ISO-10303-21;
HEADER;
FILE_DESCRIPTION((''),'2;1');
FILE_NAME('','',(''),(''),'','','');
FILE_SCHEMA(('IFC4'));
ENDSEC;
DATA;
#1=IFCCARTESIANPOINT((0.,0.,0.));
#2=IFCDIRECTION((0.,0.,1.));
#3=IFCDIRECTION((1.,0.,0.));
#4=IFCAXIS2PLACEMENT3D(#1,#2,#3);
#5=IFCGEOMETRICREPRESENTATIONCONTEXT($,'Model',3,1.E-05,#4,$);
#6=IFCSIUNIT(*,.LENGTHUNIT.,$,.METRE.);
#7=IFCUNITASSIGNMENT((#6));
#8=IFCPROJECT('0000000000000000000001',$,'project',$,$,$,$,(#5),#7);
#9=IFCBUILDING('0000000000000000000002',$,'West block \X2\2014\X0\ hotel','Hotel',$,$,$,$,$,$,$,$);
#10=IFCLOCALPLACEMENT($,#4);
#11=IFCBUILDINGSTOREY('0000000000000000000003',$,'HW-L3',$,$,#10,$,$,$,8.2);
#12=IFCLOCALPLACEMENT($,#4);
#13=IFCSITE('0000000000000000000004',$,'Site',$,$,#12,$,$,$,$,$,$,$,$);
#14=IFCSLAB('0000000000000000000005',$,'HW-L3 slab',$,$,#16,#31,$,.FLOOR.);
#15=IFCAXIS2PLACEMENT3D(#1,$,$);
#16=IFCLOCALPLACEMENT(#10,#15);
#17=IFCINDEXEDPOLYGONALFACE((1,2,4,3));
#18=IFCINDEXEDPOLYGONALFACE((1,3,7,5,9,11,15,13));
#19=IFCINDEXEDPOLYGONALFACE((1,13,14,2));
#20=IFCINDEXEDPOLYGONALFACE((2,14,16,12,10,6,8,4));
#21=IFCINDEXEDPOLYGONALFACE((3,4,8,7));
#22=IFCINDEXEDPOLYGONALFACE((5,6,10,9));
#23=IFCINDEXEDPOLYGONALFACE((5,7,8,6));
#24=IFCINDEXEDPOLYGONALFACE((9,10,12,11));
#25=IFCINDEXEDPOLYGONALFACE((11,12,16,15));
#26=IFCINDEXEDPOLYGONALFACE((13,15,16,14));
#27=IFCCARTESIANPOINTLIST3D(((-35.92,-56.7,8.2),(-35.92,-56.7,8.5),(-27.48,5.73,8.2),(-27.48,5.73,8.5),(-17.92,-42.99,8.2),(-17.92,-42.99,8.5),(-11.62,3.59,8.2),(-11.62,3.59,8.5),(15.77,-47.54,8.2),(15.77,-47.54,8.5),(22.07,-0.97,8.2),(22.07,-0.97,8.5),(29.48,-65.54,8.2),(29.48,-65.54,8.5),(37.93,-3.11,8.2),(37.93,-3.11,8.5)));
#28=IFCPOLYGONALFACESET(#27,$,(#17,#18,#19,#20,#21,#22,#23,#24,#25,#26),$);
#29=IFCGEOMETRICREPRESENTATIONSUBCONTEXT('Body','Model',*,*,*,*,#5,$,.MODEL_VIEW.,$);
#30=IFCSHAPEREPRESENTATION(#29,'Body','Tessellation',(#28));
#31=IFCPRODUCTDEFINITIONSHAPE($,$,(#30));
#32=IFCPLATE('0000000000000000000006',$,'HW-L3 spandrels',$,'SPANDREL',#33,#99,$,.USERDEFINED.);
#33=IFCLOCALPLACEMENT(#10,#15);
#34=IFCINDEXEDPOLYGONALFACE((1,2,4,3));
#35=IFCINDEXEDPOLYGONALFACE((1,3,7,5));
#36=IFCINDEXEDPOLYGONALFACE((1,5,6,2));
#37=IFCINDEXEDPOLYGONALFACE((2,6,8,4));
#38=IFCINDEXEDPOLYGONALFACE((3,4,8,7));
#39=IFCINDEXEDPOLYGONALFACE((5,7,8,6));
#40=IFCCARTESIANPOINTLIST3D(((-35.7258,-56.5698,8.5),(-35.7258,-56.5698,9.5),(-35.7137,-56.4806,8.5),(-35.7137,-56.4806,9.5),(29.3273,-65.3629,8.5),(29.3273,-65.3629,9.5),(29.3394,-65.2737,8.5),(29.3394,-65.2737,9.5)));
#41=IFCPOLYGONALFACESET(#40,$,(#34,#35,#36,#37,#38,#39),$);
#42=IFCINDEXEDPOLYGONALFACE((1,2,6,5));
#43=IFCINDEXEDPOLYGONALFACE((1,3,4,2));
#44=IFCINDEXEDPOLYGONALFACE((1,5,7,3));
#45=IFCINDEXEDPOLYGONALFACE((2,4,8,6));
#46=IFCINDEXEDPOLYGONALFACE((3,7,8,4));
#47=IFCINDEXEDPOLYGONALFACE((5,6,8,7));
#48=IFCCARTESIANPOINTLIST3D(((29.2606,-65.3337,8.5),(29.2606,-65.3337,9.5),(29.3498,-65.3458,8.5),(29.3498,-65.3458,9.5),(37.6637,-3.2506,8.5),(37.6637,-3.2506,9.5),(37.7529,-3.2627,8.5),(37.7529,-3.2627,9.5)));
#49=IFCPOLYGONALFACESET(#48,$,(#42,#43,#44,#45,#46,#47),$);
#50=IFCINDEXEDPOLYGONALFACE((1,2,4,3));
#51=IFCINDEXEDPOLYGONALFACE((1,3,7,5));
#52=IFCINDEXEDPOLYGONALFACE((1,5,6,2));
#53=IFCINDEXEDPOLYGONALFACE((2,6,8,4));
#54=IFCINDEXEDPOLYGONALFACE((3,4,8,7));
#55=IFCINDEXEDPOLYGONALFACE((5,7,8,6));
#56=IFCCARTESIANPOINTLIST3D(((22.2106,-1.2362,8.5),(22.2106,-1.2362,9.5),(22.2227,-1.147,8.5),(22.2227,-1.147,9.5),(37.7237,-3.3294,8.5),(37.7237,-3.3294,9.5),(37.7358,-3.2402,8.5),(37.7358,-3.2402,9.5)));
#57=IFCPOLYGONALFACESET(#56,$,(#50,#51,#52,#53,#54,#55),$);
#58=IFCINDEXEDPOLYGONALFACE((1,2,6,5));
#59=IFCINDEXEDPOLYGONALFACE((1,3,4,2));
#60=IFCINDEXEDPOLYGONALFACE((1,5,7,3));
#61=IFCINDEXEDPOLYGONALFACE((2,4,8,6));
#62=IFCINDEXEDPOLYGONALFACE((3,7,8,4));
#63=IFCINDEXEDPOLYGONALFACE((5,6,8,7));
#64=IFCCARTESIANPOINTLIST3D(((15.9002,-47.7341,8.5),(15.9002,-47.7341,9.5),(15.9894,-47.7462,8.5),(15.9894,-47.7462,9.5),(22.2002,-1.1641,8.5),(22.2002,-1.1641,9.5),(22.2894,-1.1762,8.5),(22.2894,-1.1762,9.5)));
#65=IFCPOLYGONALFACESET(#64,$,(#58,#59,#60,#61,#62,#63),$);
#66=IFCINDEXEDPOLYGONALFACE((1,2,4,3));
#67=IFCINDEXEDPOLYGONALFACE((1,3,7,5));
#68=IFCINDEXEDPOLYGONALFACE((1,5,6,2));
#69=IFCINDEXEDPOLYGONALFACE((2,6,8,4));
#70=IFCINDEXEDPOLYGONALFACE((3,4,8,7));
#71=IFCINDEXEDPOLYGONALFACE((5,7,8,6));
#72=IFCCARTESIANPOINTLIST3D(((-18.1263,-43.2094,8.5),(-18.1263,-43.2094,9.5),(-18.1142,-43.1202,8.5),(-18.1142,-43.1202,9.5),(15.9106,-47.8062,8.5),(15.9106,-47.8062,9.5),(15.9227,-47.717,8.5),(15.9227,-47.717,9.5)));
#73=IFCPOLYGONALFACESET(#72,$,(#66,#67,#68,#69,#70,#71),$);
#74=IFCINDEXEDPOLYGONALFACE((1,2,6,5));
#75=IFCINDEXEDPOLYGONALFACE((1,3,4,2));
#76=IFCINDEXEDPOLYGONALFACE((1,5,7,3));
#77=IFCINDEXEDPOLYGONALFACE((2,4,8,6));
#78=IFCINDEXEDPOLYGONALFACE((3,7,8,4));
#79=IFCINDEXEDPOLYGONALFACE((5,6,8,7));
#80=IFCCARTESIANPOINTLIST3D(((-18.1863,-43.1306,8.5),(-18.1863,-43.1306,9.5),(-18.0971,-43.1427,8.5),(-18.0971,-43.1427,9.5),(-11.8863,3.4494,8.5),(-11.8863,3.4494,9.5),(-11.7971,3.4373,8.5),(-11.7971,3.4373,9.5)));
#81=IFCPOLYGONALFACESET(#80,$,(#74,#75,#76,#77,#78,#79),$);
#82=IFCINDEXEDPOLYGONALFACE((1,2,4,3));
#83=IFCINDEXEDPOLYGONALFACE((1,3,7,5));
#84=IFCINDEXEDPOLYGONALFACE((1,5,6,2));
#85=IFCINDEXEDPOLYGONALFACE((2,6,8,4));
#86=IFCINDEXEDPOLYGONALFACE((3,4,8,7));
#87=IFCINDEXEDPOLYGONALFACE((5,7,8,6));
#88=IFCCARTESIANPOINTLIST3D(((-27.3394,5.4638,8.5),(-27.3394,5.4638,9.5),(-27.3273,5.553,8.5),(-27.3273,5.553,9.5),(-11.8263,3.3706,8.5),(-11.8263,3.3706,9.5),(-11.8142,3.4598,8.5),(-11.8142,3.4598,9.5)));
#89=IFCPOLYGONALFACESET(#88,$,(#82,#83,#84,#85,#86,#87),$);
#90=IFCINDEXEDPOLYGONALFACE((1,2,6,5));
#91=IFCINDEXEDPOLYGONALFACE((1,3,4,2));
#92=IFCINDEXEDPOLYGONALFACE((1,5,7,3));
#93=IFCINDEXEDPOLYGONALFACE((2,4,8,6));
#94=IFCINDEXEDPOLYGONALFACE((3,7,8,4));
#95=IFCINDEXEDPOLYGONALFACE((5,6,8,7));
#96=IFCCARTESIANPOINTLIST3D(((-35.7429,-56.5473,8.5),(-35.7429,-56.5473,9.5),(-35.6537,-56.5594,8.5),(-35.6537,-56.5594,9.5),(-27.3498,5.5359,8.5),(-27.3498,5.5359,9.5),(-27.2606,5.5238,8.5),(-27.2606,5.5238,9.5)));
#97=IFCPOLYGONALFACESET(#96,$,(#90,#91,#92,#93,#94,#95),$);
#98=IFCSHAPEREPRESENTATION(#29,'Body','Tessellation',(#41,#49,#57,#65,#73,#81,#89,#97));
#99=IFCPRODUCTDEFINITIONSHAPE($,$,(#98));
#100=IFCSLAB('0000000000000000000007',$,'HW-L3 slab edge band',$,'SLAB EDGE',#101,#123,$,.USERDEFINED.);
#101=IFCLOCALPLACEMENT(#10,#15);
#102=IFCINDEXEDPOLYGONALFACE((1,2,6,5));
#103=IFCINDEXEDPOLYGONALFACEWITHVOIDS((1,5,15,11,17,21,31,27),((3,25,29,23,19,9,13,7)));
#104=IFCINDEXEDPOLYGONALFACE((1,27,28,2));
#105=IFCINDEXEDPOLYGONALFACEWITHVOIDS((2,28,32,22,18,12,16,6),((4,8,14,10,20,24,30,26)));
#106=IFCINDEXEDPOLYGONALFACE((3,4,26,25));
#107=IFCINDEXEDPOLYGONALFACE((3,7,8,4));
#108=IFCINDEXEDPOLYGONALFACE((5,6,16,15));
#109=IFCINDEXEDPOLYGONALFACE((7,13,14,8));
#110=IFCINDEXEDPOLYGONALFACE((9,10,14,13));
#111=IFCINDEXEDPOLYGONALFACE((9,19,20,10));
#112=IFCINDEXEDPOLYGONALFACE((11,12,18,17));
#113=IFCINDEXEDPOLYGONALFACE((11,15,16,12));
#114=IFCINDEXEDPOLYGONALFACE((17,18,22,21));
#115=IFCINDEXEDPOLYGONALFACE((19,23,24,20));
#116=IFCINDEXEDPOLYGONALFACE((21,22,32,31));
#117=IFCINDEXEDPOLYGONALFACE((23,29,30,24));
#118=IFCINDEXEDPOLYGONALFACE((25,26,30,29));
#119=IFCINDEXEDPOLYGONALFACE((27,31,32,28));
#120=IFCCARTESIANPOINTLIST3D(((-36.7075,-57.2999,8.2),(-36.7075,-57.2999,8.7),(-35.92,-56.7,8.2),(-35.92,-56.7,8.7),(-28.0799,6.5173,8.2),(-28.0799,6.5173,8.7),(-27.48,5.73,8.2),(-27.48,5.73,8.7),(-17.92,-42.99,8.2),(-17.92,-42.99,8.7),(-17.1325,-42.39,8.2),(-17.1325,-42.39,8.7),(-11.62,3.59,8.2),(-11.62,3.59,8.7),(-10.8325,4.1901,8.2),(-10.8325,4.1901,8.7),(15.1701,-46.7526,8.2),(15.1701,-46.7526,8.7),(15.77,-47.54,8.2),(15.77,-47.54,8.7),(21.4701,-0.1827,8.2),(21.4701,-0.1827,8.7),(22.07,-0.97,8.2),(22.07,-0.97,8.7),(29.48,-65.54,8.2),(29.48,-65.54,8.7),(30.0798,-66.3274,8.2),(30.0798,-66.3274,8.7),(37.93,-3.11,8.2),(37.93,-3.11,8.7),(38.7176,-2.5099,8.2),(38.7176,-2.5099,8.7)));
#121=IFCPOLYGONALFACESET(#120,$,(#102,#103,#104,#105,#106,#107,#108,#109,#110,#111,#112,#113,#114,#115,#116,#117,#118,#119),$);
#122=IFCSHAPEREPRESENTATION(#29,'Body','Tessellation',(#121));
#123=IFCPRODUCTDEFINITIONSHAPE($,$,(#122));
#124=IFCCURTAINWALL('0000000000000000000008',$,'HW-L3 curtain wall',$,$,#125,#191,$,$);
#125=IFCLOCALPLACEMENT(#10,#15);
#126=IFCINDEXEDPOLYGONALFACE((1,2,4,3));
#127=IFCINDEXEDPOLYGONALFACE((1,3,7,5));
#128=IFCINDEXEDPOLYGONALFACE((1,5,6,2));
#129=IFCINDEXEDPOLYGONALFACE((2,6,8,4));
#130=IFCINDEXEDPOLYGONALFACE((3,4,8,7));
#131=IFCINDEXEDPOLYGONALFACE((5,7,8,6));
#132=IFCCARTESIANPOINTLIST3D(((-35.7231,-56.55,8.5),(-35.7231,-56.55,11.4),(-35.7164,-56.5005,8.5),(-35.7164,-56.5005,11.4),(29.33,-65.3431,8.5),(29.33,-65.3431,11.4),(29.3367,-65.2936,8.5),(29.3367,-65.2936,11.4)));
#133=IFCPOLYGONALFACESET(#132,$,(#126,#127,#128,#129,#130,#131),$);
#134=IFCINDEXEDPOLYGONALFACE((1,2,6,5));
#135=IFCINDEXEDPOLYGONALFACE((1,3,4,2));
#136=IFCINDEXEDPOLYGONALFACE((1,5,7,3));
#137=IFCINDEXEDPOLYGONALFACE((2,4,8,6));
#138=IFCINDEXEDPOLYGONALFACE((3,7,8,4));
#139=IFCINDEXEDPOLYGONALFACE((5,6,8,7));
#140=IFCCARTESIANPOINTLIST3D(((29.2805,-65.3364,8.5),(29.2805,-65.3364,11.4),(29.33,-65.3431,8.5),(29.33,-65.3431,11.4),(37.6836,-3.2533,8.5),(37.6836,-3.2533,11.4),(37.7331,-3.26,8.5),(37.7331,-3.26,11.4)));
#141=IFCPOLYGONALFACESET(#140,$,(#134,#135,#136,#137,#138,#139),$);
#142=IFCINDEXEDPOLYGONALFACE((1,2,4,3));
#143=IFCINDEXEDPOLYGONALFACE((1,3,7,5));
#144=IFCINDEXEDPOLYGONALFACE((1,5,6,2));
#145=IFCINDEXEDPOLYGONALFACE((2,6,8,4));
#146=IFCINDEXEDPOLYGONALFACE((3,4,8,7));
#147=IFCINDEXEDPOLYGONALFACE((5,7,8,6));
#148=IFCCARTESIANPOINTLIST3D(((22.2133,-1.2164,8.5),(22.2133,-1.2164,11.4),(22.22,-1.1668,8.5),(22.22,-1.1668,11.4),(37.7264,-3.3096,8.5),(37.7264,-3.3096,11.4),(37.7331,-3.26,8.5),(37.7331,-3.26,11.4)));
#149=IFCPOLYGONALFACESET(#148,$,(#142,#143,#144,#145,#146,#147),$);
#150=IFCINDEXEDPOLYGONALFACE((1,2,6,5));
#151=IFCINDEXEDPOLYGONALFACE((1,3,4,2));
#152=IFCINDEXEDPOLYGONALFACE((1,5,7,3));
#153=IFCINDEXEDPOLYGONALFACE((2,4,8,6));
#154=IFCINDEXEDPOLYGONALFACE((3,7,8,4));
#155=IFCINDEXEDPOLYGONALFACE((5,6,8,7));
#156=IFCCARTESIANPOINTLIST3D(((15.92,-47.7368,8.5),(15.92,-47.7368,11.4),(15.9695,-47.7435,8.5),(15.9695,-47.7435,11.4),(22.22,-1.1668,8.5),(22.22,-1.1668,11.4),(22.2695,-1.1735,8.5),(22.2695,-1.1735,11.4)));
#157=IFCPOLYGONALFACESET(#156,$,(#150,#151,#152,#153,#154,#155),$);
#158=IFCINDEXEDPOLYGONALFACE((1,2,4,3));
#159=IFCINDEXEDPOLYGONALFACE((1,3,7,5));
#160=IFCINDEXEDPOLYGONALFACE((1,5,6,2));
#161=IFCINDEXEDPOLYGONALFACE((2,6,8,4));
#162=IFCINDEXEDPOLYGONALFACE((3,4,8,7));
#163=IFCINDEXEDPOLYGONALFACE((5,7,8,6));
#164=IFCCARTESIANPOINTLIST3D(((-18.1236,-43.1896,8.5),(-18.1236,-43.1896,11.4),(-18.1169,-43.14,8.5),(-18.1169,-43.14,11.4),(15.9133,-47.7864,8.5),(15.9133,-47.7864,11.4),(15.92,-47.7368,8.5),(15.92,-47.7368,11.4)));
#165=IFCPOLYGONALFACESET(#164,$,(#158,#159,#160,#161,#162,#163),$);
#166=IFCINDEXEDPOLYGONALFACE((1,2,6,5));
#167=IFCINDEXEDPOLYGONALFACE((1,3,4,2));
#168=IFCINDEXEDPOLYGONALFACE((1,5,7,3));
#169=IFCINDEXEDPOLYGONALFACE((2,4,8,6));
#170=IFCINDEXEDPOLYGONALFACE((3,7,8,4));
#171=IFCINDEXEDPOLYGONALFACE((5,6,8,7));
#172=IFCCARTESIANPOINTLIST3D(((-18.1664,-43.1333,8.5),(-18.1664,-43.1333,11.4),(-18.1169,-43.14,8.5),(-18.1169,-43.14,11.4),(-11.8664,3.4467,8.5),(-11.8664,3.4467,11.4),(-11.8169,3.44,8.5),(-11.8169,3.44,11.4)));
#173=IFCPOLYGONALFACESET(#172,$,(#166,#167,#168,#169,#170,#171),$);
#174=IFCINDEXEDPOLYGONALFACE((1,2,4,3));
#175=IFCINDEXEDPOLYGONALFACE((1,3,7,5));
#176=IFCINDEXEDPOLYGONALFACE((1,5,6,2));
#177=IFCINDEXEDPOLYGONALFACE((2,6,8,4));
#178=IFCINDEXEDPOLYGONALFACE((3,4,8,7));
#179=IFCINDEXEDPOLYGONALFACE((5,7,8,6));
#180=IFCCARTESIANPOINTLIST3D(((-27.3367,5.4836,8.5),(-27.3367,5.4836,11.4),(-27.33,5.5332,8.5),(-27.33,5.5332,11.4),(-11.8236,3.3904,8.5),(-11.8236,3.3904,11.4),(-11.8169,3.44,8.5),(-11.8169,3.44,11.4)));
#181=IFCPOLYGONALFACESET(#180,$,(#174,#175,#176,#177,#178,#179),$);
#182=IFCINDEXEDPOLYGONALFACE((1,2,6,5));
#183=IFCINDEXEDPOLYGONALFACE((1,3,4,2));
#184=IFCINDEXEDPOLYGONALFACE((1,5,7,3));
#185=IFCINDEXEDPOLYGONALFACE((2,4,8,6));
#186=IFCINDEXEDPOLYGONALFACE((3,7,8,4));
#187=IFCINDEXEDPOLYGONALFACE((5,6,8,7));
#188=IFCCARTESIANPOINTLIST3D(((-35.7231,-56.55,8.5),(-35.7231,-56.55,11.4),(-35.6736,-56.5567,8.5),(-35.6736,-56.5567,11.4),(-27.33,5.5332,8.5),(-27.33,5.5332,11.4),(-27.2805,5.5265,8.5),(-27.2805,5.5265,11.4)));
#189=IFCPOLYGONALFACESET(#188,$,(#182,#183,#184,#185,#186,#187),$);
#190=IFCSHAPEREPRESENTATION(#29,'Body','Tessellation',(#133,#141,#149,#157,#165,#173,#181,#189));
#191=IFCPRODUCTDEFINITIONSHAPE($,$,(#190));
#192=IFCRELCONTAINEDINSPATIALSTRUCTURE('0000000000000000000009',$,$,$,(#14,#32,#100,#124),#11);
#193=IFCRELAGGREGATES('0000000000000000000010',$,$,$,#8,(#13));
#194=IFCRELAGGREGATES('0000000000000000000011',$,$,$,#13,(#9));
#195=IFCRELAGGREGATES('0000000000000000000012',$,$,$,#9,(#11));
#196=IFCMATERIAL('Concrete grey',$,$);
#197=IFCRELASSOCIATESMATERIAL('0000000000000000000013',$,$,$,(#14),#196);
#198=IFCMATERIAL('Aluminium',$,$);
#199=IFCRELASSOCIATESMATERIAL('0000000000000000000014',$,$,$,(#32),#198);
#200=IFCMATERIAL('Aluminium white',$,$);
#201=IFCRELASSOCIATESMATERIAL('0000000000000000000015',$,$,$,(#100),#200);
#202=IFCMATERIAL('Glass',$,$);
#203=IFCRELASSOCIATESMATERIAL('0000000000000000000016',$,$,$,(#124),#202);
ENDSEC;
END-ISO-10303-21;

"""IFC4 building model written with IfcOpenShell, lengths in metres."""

from ifc_helpers import new_model, si_unit, frame, origin_with_axes, place, context, subcontext, project, spatial, polyline, outline, extrude, material, element, save


model = new_model("IFC4")

# Units and contexts
model_context = context("Model", 3, precision=1e-05, world=origin_with_axes())
body_context = subcontext(model_context, "Body", "Model", "MODEL_VIEW")
ifc_project = project(units=[si_unit("LENGTHUNIT", "METRE")], contexts=[model_context])

# Site, building, storey
site_placement = place(None, origin_with_axes())
site = spatial("IfcSite", under=ifc_project, at=site_placement, Name="Site")
building = spatial("IfcBuilding", under=site, Name="West block — hotel", Description="Hotel")
storey_placement = place(None, origin_with_axes())
storey = spatial("IfcBuildingStorey", under=building, at=storey_placement, Name="HW-L3", Elevation=8.2)

# Shared definitions
ifc_material_1 = material(Name="Aluminium")

# Slab
ifc_material_2 = material(Name="Concrete grey")
slab_1_placement = place(storey_placement, origin_with_axes())
element("IfcSlab", 1, at=slab_1_placement, inside=storey, material=ifc_material_2, Name="HW-L3 slab", PredefinedType="FLOOR", context=body_context, shape_type="SweptSolid", body=[
    extrude(outline(polyline([(-35.92, -56.7), (29.48, -65.54), (37.93, -3.11), (22.07, -0.97), (15.77, -47.54), (-17.92, -42.99), (-11.62, 3.59), (-27.48, 5.73), (-35.92, -56.7)])), frame((0.0, 0.0, 8.2), z_axis=(0.0, 0.0, 1.0), x_axis=(1.0, 0.0, 0.0)), (0.0, 0.0, 1.0), 0.3),
])

# Plate
plate_placement = place(storey_placement, origin_with_axes())
element("IfcPlate", 2, at=plate_placement, inside=storey, material=ifc_material_1, Name="HW-L3 spandrels", ObjectType="SPANDREL", PredefinedType="USERDEFINED", context=body_context, shape_type="SweptSolid", body=[
    extrude(outline(polyline([(-35.7258, -56.5698), (29.3273, -65.3629), (29.3394, -65.2737), (-35.7137, -56.4806), (-35.7258, -56.5698)])), frame((0.0, 0.0, 8.5), z_axis=(0.0, 0.0, 1.0), x_axis=(1.0, 0.0, 0.0)), (0.0, 0.0, 1.0), 1.0),
    extrude(outline(polyline([(29.3498, -65.3458), (37.7529, -3.2627), (37.6637, -3.2506), (29.2606, -65.3337), (29.3498, -65.3458)])), frame((0.0, 0.0, 8.5), z_axis=(0.0, 0.0, 1.0), x_axis=(1.0, 0.0, 0.0)), (0.0, 0.0, 1.0), 1.0),
    extrude(outline(polyline([(37.7358, -3.2402), (22.2227, -1.147), (22.2106, -1.2362), (37.7237, -3.3294), (37.7358, -3.2402)])), frame((0.0, 0.0, 8.5), z_axis=(0.0, 0.0, 1.0), x_axis=(1.0, 0.0, 0.0)), (0.0, 0.0, 1.0), 1.0),
    extrude(outline(polyline([(22.2002, -1.1641), (15.9002, -47.7341), (15.9894, -47.7462), (22.2894, -1.1762), (22.2002, -1.1641)])), frame((0.0, 0.0, 8.5), z_axis=(0.0, 0.0, 1.0), x_axis=(1.0, 0.0, 0.0)), (0.0, 0.0, 1.0), 1.0),
    extrude(outline(polyline([(15.9227, -47.717), (-18.1142, -43.1202), (-18.1263, -43.2094), (15.9106, -47.8062), (15.9227, -47.717)])), frame((0.0, 0.0, 8.5), z_axis=(0.0, 0.0, 1.0), x_axis=(1.0, 0.0, 0.0)), (0.0, 0.0, 1.0), 1.0),
    extrude(outline(polyline([(-18.0971, -43.1427), (-11.7971, 3.4373), (-11.8863, 3.4494), (-18.1863, -43.1306), (-18.0971, -43.1427)])), frame((0.0, 0.0, 8.5), z_axis=(0.0, 0.0, 1.0), x_axis=(1.0, 0.0, 0.0)), (0.0, 0.0, 1.0), 1.0),
    extrude(outline(polyline([(-11.8142, 3.4598), (-27.3273, 5.553), (-27.3394, 5.4638), (-11.8263, 3.3706), (-11.8142, 3.4598)])), frame((0.0, 0.0, 8.5), z_axis=(0.0, 0.0, 1.0), x_axis=(1.0, 0.0, 0.0)), (0.0, 0.0, 1.0), 1.0),
    extrude(outline(polyline([(-27.3498, 5.5359), (-35.7429, -56.5473), (-35.6537, -56.5594), (-27.2606, 5.5238), (-27.3498, 5.5359)])), frame((0.0, 0.0, 8.5), z_axis=(0.0, 0.0, 1.0), x_axis=(1.0, 0.0, 0.0)), (0.0, 0.0, 1.0), 1.0),
])

# Slab
ifc_material_3 = material(Name="Aluminium white")
slab_2_placement = place(storey_placement, origin_with_axes())
element("IfcSlab", 3, at=slab_2_placement, inside=storey, material=ifc_material_3, Name="HW-L3 slab edge band", ObjectType="SLAB EDGE", PredefinedType="USERDEFINED", context=body_context, shape_type="SweptSolid", body=[
    extrude(outline(polyline([(-36.7075, -57.2999), (30.0798, -66.3274), (38.7176, -2.5099), (21.4701, -0.1827), (15.1701, -46.7526), (-17.1325, -42.39), (-10.8325, 4.1901), (-28.0799, 6.5173), (-36.7075, -57.2999)]), holes=[polyline([(-35.92, -56.7), (29.48, -65.54), (37.93, -3.11), (22.07, -0.97), (15.77, -47.54), (-17.92, -42.99), (-11.62, 3.59), (-27.48, 5.73), (-35.92, -56.7)])]), frame((0.0, 0.0, 8.2), z_axis=(0.0, 0.0, 1.0), x_axis=(1.0, 0.0, 0.0)), (0.0, 0.0, 1.0), 0.5),
])

# Curtain wall
ifc_material_4 = material(Name="Glass")
curtain_wall_placement = place(storey_placement, origin_with_axes())
element("IfcCurtainWall", 4, at=curtain_wall_placement, inside=storey, material=ifc_material_4, Name="HW-L3 curtain wall", context=body_context, shape_type="SweptSolid", body=[
    extrude(outline(polyline([(-35.7231, -56.55), (29.33, -65.3431), (29.3367, -65.2936), (-35.7164, -56.5005), (-35.7231, -56.55)])), frame((0.0, 0.0, 8.5), z_axis=(0.0, 0.0, 1.0), x_axis=(1.0, 0.0, 0.0)), (0.0, 0.0, 1.0), 2.9),
    extrude(outline(polyline([(29.33, -65.3431), (37.7331, -3.26), (37.6836, -3.2533), (29.2805, -65.3364), (29.33, -65.3431)])), frame((0.0, 0.0, 8.5), z_axis=(0.0, 0.0, 1.0), x_axis=(1.0, 0.0, 0.0)), (0.0, 0.0, 1.0), 2.9),
    extrude(outline(polyline([(37.7331, -3.26), (22.22, -1.1668), (22.2133, -1.2164), (37.7264, -3.3096), (37.7331, -3.26)])), frame((0.0, 0.0, 8.5), z_axis=(0.0, 0.0, 1.0), x_axis=(1.0, 0.0, 0.0)), (0.0, 0.0, 1.0), 2.9),
    extrude(outline(polyline([(22.22, -1.1668), (15.92, -47.7368), (15.9695, -47.7435), (22.2695, -1.1735), (22.22, -1.1668)])), frame((0.0, 0.0, 8.5), z_axis=(0.0, 0.0, 1.0), x_axis=(1.0, 0.0, 0.0)), (0.0, 0.0, 1.0), 2.9),
    extrude(outline(polyline([(15.92, -47.7368), (-18.1169, -43.14), (-18.1236, -43.1896), (15.9133, -47.7864), (15.92, -47.7368)])), frame((0.0, 0.0, 8.5), z_axis=(0.0, 0.0, 1.0), x_axis=(1.0, 0.0, 0.0)), (0.0, 0.0, 1.0), 2.9),
    extrude(outline(polyline([(-18.1169, -43.14), (-11.8169, 3.44), (-11.8664, 3.4467), (-18.1664, -43.1333), (-18.1169, -43.14)])), frame((0.0, 0.0, 8.5), z_axis=(0.0, 0.0, 1.0), x_axis=(1.0, 0.0, 0.0)), (0.0, 0.0, 1.0), 2.9),
    extrude(outline(polyline([(-11.8169, 3.44), (-27.33, 5.5332), (-27.3367, 5.4836), (-11.8236, 3.3904), (-11.8169, 3.44)])), frame((0.0, 0.0, 8.5), z_axis=(0.0, 0.0, 1.0), x_axis=(1.0, 0.0, 0.0)), (0.0, 0.0, 1.0), 2.9),
    extrude(outline(polyline([(-27.33, 5.5332), (-35.7231, -56.55), (-35.6736, -56.5567), (-27.2805, 5.5265), (-27.33, 5.5332)])), frame((0.0, 0.0, 8.5), z_axis=(0.0, 0.0, 1.0), x_axis=(1.0, 0.0, 0.0)), (0.0, 0.0, 1.0), 2.9),
])

save(model, "model.ifc")
